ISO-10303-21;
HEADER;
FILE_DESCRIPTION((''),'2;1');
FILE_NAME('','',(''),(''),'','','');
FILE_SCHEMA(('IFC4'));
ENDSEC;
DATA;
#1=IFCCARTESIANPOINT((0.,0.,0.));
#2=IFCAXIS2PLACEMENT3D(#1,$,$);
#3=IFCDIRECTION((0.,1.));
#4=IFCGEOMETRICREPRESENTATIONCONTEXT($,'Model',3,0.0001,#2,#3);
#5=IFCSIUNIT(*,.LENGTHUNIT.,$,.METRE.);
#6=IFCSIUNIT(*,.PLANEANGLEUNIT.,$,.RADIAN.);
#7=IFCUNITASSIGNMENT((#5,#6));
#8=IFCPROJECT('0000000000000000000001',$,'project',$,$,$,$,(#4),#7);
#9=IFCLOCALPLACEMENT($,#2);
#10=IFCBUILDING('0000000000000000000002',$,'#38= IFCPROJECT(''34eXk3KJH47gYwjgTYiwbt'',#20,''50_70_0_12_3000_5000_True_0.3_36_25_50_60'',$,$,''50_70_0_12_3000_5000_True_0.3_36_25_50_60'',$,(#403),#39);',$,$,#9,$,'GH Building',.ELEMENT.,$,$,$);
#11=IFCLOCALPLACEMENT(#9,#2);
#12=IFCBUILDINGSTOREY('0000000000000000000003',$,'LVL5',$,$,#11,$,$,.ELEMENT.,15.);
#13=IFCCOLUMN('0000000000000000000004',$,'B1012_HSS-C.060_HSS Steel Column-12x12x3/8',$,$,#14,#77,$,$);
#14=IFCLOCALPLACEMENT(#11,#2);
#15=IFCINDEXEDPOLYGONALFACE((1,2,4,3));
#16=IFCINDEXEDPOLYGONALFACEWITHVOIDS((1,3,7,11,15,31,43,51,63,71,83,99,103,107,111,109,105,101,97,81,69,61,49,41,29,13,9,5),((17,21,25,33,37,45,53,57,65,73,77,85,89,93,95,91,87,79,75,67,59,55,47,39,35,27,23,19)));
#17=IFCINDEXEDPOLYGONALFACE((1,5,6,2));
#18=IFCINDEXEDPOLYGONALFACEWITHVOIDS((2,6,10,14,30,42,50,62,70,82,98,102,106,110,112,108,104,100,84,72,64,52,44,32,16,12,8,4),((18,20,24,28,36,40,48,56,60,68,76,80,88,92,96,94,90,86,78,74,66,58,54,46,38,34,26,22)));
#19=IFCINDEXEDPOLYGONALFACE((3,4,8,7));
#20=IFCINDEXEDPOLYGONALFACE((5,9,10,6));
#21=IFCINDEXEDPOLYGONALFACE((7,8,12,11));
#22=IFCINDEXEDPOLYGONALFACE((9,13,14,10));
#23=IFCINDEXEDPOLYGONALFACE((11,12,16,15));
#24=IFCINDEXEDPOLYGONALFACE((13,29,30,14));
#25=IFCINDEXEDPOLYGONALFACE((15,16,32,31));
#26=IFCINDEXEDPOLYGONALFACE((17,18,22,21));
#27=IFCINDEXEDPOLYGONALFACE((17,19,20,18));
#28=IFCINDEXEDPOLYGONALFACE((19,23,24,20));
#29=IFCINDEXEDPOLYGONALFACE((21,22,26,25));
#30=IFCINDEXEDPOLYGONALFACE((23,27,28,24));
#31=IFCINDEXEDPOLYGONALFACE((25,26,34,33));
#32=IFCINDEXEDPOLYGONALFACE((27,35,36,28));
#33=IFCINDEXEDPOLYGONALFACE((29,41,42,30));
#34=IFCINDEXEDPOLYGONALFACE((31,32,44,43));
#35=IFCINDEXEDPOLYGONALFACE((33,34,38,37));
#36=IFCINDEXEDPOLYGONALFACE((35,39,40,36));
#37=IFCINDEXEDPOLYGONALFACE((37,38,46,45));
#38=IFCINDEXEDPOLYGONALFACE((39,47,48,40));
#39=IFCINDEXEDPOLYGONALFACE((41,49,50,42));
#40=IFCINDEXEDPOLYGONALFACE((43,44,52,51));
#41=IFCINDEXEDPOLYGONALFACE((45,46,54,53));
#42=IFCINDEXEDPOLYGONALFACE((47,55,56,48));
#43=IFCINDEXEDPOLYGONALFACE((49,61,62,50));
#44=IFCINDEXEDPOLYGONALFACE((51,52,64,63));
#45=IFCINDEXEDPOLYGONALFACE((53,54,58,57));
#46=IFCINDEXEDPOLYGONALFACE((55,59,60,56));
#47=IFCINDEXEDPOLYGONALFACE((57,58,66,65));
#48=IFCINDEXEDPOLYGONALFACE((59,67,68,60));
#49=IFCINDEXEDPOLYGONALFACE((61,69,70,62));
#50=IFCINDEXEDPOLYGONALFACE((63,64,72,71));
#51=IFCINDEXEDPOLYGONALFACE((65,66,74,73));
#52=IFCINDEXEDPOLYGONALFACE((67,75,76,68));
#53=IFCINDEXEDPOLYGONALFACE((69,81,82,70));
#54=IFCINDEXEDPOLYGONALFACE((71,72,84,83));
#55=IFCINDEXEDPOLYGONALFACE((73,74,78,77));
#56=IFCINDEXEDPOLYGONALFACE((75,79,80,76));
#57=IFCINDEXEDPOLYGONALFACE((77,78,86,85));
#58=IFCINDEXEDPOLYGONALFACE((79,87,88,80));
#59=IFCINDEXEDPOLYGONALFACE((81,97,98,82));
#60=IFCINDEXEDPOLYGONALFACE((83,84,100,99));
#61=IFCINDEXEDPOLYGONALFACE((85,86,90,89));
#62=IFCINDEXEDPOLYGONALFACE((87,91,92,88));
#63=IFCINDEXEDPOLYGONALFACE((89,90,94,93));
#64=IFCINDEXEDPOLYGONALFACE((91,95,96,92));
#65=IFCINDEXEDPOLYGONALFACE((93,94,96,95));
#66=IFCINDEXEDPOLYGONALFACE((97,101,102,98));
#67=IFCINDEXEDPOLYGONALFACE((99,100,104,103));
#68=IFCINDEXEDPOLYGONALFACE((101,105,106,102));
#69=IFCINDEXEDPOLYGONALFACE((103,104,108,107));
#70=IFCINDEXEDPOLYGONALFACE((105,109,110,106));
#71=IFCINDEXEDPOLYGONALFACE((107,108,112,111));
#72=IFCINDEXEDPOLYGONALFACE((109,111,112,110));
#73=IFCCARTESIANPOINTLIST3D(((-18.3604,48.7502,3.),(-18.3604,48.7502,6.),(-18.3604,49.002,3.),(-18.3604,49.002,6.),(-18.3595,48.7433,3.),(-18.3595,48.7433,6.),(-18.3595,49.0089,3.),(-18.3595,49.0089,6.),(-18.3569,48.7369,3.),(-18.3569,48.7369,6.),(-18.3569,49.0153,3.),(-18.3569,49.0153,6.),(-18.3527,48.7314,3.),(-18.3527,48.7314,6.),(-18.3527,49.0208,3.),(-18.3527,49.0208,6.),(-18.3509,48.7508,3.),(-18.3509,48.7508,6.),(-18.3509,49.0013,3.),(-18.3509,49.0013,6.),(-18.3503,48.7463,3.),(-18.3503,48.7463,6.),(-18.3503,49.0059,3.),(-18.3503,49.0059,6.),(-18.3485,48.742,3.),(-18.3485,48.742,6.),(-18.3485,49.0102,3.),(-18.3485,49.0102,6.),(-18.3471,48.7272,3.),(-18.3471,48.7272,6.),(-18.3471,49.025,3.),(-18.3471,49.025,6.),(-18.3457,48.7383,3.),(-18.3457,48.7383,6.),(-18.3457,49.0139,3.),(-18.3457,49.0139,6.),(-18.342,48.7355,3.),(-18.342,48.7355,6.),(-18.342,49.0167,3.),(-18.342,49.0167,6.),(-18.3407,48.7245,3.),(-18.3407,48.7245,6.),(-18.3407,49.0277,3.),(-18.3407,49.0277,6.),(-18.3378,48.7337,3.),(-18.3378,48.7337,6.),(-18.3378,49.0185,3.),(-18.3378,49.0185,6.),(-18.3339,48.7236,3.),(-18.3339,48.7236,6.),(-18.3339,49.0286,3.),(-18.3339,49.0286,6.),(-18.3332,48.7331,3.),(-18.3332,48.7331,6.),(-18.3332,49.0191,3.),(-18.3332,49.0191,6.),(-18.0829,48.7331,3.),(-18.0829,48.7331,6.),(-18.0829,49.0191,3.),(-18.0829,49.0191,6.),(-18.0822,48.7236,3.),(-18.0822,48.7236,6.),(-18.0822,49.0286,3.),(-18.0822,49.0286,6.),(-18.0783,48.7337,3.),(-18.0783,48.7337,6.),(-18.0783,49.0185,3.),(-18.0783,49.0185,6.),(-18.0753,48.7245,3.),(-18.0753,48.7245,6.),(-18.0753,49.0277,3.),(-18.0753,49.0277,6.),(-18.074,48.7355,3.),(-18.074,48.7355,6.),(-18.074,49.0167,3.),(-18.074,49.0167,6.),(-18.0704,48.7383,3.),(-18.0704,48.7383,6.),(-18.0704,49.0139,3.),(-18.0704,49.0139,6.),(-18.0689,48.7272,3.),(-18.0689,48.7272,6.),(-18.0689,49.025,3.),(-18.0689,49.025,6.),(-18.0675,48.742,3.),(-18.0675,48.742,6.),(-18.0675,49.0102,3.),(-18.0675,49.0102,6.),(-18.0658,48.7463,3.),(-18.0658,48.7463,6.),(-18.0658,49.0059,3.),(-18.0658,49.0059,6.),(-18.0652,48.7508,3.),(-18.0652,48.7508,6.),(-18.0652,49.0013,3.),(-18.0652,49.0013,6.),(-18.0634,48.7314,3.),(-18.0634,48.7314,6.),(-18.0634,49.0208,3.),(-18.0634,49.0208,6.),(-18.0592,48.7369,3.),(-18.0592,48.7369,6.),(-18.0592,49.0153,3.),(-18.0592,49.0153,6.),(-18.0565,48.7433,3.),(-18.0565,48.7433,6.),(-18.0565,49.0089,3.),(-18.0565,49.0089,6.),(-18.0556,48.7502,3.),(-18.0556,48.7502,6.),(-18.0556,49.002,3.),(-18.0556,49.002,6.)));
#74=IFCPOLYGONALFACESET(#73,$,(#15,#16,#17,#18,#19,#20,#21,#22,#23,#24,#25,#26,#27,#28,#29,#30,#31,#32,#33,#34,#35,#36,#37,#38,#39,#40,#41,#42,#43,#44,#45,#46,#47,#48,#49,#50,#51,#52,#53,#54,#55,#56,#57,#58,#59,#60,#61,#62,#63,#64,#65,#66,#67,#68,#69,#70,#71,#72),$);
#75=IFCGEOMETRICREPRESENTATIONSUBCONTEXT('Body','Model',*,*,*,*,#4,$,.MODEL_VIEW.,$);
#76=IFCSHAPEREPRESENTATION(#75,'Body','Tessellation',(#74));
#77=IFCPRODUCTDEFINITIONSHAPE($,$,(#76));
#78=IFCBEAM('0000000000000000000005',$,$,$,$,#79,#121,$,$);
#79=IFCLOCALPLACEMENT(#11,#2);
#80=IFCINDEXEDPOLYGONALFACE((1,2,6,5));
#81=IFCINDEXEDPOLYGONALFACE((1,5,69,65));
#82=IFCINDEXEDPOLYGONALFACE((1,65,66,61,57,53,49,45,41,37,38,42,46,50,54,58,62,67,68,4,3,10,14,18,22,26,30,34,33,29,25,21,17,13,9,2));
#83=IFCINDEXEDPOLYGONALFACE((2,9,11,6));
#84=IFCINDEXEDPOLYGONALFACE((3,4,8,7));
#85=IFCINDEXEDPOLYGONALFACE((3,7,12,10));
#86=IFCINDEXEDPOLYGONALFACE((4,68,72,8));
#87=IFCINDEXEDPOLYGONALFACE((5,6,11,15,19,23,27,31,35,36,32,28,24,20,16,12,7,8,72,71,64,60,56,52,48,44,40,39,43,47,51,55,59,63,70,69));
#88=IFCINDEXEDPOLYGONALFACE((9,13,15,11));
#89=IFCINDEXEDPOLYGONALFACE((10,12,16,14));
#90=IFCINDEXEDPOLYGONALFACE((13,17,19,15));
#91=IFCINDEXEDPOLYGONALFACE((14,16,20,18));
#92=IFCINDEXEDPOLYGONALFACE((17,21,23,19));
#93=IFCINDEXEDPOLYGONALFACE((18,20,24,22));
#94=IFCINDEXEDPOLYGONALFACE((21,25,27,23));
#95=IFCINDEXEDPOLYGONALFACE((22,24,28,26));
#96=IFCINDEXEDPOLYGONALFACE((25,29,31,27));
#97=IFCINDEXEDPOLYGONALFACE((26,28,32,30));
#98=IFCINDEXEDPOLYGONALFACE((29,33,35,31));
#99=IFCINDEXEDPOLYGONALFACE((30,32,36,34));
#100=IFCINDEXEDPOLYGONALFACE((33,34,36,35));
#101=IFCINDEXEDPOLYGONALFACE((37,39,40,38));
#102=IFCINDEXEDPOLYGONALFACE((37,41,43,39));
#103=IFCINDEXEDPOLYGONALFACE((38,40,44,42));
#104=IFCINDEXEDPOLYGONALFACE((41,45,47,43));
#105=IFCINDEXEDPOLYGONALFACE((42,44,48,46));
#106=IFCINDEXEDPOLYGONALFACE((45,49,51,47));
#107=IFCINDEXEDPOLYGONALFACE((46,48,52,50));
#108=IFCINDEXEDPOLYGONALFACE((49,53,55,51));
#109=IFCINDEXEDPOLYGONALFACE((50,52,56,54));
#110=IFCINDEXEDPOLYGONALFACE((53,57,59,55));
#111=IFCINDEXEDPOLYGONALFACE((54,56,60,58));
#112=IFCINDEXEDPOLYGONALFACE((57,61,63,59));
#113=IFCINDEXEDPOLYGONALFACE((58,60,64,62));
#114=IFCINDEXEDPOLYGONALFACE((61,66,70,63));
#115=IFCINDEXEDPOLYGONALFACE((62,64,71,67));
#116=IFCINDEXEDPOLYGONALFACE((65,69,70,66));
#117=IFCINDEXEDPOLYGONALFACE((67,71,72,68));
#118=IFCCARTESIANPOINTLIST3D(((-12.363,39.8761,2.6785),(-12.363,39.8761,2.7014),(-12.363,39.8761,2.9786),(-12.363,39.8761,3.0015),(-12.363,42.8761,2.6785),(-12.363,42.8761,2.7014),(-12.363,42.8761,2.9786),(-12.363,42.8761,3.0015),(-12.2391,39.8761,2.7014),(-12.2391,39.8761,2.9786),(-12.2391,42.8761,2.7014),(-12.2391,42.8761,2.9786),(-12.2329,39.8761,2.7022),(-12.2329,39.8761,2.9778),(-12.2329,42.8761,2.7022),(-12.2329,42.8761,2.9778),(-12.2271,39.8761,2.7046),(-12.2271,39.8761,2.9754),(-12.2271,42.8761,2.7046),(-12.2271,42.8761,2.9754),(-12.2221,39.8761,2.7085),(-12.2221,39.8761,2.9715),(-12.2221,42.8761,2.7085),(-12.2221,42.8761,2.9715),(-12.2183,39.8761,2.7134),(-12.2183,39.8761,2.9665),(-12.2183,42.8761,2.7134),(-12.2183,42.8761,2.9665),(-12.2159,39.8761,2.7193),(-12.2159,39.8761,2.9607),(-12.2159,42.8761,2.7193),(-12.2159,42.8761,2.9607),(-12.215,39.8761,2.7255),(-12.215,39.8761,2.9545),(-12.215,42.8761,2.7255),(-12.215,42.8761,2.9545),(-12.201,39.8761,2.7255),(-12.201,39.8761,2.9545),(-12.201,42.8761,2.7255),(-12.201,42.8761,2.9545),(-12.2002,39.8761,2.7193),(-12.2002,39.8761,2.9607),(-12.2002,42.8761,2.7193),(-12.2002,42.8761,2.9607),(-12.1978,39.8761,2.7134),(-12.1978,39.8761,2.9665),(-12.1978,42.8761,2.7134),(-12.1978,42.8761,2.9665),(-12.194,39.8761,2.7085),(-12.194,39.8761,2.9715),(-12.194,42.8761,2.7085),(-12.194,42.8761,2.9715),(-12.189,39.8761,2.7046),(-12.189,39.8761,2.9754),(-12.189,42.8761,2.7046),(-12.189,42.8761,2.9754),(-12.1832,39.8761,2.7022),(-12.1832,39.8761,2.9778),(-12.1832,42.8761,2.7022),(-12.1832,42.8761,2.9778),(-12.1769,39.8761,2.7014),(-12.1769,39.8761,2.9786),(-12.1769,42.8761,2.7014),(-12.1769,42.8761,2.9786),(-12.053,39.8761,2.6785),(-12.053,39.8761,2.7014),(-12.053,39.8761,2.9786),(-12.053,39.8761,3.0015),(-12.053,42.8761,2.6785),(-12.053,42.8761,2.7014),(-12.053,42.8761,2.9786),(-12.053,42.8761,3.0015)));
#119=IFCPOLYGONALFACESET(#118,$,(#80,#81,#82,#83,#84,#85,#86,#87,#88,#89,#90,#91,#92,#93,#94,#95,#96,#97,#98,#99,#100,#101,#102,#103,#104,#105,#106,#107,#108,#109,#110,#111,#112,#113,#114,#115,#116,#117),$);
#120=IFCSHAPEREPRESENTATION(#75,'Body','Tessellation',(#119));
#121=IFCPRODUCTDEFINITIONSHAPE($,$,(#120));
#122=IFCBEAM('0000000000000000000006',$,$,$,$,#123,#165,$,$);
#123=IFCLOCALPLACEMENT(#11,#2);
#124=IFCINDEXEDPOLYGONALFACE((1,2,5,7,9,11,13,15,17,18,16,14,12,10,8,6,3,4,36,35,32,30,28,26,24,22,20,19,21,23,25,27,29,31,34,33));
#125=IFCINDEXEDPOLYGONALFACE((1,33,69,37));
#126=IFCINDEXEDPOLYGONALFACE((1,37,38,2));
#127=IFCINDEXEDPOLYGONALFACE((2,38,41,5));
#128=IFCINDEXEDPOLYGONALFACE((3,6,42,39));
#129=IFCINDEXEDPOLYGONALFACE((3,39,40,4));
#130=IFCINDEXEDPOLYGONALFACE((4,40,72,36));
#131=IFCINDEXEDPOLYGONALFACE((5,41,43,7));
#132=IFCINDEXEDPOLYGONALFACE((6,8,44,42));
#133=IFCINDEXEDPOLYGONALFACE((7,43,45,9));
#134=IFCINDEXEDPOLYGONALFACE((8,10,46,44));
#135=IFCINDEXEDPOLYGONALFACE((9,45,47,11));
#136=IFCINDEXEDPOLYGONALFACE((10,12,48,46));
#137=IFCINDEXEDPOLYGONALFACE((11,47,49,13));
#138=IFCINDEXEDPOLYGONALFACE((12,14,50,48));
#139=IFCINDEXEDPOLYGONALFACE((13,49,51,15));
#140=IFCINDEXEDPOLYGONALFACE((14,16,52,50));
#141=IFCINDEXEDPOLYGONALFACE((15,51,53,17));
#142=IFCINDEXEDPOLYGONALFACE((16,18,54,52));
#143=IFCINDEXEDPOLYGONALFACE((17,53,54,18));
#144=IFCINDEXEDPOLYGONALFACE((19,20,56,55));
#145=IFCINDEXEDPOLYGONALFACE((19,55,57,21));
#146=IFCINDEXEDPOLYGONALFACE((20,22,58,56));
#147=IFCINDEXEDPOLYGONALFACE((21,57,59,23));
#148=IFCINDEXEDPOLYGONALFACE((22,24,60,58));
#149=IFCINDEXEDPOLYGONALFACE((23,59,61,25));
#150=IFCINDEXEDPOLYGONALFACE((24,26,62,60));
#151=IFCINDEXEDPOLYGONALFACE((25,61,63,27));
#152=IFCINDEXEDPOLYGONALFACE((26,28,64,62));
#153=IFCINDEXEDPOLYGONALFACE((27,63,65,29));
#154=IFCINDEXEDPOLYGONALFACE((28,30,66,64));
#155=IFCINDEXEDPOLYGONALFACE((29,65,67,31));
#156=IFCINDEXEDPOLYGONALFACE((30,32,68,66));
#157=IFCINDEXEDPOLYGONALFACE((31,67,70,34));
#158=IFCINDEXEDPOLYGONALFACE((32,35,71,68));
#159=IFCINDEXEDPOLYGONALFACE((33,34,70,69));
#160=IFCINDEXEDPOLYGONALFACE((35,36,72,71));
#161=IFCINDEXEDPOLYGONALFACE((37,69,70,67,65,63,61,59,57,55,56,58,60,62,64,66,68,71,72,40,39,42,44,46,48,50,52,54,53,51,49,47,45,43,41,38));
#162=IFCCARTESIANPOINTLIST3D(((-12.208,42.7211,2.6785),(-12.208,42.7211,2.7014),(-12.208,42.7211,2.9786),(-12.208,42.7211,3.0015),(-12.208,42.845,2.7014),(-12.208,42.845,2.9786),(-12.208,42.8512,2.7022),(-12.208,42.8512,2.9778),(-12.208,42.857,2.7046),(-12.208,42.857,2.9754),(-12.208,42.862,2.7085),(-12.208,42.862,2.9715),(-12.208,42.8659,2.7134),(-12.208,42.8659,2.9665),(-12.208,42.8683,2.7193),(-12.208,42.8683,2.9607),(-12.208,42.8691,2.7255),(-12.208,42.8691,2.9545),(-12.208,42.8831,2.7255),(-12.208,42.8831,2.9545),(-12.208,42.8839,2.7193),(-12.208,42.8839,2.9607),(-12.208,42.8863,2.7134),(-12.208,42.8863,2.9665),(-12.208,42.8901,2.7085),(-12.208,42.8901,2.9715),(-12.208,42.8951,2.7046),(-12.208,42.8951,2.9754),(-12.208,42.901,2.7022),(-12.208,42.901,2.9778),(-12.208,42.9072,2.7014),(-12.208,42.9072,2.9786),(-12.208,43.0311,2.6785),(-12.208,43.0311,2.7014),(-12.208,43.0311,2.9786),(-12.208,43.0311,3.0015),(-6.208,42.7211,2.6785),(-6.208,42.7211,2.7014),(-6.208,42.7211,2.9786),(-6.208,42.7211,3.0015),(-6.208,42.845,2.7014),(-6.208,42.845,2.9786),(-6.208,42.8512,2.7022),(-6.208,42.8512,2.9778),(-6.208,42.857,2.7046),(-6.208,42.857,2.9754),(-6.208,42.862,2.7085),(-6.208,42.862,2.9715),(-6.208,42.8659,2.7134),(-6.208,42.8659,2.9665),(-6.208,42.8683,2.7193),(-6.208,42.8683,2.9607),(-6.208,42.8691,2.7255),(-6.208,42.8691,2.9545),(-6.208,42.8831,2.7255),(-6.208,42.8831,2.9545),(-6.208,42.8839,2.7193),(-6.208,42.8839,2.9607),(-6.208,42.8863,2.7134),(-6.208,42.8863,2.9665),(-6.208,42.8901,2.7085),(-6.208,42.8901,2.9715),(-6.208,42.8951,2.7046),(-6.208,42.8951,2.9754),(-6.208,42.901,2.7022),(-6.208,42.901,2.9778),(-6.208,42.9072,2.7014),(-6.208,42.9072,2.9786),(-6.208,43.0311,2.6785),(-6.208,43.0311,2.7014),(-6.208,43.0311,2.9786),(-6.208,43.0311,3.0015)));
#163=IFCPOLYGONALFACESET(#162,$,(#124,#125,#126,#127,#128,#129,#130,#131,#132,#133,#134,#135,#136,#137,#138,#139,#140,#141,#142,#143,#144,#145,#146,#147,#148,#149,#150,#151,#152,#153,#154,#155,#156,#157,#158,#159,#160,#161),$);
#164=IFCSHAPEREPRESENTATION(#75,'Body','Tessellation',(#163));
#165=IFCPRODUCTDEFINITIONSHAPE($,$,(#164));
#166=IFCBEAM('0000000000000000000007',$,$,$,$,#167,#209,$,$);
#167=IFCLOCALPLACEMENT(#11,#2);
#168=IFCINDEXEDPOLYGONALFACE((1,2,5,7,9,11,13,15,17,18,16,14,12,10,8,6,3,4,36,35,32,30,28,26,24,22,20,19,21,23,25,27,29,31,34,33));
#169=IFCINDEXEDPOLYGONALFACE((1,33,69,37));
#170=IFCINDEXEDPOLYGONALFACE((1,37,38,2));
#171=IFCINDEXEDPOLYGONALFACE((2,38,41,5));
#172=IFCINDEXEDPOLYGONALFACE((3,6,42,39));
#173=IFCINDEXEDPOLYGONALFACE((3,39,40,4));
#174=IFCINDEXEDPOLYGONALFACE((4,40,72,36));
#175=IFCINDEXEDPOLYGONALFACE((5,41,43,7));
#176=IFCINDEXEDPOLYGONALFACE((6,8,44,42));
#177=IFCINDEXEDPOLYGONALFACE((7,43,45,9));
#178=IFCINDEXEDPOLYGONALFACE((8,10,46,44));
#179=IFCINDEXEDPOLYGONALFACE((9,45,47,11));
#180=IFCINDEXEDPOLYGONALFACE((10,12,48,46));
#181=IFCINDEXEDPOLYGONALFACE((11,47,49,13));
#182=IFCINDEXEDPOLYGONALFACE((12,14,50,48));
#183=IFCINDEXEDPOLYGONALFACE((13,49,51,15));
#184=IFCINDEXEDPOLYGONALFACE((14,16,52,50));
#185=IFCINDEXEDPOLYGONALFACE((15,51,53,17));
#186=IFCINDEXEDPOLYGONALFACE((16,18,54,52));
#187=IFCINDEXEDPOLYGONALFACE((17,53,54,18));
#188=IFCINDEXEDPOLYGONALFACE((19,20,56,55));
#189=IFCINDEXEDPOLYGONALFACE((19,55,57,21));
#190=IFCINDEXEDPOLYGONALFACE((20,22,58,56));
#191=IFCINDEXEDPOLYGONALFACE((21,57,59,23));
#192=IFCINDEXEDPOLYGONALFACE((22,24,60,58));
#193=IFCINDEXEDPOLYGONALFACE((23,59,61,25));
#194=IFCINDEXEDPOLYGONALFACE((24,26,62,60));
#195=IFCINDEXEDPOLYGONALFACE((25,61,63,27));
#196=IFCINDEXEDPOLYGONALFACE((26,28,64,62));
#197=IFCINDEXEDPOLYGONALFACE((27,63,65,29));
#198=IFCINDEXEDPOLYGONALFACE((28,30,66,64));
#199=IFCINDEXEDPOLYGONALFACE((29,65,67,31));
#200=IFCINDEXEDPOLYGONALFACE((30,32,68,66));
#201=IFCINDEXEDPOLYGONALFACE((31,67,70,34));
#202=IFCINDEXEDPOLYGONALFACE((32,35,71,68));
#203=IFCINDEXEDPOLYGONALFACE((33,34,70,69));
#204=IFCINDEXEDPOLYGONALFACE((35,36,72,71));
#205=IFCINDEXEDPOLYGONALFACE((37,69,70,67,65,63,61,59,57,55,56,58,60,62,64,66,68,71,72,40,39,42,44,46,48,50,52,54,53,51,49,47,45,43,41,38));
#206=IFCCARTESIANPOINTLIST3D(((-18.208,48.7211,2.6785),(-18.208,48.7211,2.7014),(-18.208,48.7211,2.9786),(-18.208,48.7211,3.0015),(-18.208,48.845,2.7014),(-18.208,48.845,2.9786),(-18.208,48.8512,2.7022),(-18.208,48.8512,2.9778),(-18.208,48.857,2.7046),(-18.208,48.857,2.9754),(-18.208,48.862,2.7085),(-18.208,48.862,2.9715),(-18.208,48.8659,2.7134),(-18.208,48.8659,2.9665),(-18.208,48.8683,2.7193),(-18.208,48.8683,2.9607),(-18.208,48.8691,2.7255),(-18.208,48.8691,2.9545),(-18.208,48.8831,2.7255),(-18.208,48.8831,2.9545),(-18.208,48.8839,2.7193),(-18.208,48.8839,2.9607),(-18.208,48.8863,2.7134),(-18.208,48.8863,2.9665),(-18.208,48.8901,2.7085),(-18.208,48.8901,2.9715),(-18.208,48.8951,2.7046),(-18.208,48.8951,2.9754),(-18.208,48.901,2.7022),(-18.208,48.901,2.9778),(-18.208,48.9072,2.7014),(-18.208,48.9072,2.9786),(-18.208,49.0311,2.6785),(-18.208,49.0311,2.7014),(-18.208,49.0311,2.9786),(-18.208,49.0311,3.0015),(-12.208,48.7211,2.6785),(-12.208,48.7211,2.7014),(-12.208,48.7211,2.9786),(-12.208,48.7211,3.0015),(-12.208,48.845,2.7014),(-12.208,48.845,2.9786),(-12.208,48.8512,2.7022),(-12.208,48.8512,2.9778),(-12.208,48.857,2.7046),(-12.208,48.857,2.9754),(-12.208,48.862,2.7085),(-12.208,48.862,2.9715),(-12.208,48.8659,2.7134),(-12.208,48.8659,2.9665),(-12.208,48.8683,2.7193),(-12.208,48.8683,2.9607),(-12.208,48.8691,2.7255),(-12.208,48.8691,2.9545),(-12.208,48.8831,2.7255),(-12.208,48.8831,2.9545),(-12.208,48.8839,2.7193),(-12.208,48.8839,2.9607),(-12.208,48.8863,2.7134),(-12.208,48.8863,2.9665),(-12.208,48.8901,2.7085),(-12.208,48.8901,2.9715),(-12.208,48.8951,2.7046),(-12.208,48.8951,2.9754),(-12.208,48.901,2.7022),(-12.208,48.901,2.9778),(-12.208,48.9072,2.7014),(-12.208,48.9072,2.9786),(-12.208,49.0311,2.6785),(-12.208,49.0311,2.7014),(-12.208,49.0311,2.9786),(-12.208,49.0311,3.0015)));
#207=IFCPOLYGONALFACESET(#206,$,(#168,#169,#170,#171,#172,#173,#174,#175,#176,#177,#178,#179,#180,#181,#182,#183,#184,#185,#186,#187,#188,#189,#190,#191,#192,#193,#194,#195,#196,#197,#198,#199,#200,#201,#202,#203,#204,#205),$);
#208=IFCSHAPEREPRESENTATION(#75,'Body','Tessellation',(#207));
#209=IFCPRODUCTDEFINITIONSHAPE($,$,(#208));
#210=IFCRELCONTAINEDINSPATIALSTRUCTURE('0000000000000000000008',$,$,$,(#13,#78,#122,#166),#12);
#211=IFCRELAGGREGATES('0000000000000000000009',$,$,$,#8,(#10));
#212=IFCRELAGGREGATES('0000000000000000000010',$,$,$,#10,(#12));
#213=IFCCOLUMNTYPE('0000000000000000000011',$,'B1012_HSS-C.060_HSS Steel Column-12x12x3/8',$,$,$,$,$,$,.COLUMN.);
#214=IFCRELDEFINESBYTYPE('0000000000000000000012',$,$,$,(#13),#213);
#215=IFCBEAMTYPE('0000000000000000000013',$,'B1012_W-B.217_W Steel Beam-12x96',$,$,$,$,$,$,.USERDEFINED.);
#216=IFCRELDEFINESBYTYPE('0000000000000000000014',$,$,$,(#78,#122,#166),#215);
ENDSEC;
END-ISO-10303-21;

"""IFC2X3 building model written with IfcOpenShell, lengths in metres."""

from ifc_helpers import new_model, si_unit, direction, frame, origin, origin_2d, place, context, subcontext, project, spatial, hollow_rectangle, i_section, extrude, type_object, element, save


model = new_model("IFC2X3")

# Units and contexts
model_context = context("Model", 3, precision=0.0001, world=origin(), true_north=direction((0.0, 1.0)))
body_context = subcontext(model_context, "Body", "Model", "MODEL_VIEW")
ifc_project = project(units=[si_unit("LENGTHUNIT", "METRE"), si_unit("PLANEANGLEUNIT", "RADIAN")], contexts=[model_context])

# Building, storey
building_placement = place(None, origin())
building = spatial("IfcBuilding", under=ifc_project, at=building_placement, Name="#38= IFCPROJECT('34eXk3KJH47gYwjgTYiwbt',#20,'50_70_0_12_3000_5000_True_0.3_36_25_50_60',$,$,'50_70_0_12_3000_5000_True_0.3_36_25_50_60',$,(#403),#39);", LongName="GH Building", CompositionType="ELEMENT")
storey_placement = place(building_placement, origin())
storey = spatial("IfcBuildingStorey", under=building, at=storey_placement, Name="LVL5", CompositionType="ELEMENT", Elevation=15.0)

# Column
column_type = type_object("IfcColumnType", Name="B1012_HSS-C.060_HSS Steel Column-12x12x3/8", PredefinedType="COLUMN")
for number, where, z_axis, x_axis, name in (
    (1, (-18.208, 48.8761, 6.0), (0.0, 0.0, -1.0), (-1.0, 0.0, 0.0), "B1012_HSS-C.060_HSS Steel Column-12x12x3/8"),
):
    element("IfcColumn", number, at=place(storey_placement, frame(where, z_axis=z_axis, x_axis=x_axis)), inside=storey, type_object=column_type, Name=name, context=body_context, shape_type="SweptSolid", body=[
        extrude(hollow_rectangle(XDim=0.3048, YDim=0.305, WallThickness=0.0095, InnerFilletRadius=0.0177, OuterFilletRadius=0.0266, at=origin_2d()), origin(), (0.0, 0.0, 1.0), 3.0),
    ])

# Beams
beam_type = type_object("IfcBeamType", Name="B1012_W-B.217_W Steel Beam-12x96", PredefinedType="USERDEFINED")
beam_1_placement = place(storey_placement, frame((-12.208, 39.8761, 2.84), z_axis=(0.0, 1.0, 0.0), x_axis=(-1.0, 0.0, 0.0)))
element("IfcBeam", 2, at=beam_1_placement, inside=storey, type_object=beam_type, context=body_context, shape_type="SweptSolid", body=[
    extrude(i_section(OverallWidth=0.31, OverallDepth=0.323, WebThickness=0.014, FlangeThickness=0.0229, FilletRadius=0.0241, at=origin_2d()), origin(), (0.0, 0.0, 1.0), 3.0),
])
for number, where, z_axis, x_axis in (
    (3, (-12.208, 42.8761, 2.84), (1.0, 0.0, 0.0), (0.0, 1.0, 0.0)),
    (4, (-18.208, 48.8761, 2.84), (1.0, 0.0, 0.0), (0.0, 1.0, 0.0)),
):
    element("IfcBeam", number, at=place(storey_placement, frame(where, z_axis=z_axis, x_axis=x_axis)), inside=storey, type_object=beam_type, context=body_context, shape_type="SweptSolid", body=[
        extrude(i_section(OverallWidth=0.31, OverallDepth=0.323, WebThickness=0.014, FlangeThickness=0.0229, FilletRadius=0.0241, at=origin_2d()), origin(), (0.0, 0.0, 1.0), 6.0),
    ])

save(model, "model.ifc")
